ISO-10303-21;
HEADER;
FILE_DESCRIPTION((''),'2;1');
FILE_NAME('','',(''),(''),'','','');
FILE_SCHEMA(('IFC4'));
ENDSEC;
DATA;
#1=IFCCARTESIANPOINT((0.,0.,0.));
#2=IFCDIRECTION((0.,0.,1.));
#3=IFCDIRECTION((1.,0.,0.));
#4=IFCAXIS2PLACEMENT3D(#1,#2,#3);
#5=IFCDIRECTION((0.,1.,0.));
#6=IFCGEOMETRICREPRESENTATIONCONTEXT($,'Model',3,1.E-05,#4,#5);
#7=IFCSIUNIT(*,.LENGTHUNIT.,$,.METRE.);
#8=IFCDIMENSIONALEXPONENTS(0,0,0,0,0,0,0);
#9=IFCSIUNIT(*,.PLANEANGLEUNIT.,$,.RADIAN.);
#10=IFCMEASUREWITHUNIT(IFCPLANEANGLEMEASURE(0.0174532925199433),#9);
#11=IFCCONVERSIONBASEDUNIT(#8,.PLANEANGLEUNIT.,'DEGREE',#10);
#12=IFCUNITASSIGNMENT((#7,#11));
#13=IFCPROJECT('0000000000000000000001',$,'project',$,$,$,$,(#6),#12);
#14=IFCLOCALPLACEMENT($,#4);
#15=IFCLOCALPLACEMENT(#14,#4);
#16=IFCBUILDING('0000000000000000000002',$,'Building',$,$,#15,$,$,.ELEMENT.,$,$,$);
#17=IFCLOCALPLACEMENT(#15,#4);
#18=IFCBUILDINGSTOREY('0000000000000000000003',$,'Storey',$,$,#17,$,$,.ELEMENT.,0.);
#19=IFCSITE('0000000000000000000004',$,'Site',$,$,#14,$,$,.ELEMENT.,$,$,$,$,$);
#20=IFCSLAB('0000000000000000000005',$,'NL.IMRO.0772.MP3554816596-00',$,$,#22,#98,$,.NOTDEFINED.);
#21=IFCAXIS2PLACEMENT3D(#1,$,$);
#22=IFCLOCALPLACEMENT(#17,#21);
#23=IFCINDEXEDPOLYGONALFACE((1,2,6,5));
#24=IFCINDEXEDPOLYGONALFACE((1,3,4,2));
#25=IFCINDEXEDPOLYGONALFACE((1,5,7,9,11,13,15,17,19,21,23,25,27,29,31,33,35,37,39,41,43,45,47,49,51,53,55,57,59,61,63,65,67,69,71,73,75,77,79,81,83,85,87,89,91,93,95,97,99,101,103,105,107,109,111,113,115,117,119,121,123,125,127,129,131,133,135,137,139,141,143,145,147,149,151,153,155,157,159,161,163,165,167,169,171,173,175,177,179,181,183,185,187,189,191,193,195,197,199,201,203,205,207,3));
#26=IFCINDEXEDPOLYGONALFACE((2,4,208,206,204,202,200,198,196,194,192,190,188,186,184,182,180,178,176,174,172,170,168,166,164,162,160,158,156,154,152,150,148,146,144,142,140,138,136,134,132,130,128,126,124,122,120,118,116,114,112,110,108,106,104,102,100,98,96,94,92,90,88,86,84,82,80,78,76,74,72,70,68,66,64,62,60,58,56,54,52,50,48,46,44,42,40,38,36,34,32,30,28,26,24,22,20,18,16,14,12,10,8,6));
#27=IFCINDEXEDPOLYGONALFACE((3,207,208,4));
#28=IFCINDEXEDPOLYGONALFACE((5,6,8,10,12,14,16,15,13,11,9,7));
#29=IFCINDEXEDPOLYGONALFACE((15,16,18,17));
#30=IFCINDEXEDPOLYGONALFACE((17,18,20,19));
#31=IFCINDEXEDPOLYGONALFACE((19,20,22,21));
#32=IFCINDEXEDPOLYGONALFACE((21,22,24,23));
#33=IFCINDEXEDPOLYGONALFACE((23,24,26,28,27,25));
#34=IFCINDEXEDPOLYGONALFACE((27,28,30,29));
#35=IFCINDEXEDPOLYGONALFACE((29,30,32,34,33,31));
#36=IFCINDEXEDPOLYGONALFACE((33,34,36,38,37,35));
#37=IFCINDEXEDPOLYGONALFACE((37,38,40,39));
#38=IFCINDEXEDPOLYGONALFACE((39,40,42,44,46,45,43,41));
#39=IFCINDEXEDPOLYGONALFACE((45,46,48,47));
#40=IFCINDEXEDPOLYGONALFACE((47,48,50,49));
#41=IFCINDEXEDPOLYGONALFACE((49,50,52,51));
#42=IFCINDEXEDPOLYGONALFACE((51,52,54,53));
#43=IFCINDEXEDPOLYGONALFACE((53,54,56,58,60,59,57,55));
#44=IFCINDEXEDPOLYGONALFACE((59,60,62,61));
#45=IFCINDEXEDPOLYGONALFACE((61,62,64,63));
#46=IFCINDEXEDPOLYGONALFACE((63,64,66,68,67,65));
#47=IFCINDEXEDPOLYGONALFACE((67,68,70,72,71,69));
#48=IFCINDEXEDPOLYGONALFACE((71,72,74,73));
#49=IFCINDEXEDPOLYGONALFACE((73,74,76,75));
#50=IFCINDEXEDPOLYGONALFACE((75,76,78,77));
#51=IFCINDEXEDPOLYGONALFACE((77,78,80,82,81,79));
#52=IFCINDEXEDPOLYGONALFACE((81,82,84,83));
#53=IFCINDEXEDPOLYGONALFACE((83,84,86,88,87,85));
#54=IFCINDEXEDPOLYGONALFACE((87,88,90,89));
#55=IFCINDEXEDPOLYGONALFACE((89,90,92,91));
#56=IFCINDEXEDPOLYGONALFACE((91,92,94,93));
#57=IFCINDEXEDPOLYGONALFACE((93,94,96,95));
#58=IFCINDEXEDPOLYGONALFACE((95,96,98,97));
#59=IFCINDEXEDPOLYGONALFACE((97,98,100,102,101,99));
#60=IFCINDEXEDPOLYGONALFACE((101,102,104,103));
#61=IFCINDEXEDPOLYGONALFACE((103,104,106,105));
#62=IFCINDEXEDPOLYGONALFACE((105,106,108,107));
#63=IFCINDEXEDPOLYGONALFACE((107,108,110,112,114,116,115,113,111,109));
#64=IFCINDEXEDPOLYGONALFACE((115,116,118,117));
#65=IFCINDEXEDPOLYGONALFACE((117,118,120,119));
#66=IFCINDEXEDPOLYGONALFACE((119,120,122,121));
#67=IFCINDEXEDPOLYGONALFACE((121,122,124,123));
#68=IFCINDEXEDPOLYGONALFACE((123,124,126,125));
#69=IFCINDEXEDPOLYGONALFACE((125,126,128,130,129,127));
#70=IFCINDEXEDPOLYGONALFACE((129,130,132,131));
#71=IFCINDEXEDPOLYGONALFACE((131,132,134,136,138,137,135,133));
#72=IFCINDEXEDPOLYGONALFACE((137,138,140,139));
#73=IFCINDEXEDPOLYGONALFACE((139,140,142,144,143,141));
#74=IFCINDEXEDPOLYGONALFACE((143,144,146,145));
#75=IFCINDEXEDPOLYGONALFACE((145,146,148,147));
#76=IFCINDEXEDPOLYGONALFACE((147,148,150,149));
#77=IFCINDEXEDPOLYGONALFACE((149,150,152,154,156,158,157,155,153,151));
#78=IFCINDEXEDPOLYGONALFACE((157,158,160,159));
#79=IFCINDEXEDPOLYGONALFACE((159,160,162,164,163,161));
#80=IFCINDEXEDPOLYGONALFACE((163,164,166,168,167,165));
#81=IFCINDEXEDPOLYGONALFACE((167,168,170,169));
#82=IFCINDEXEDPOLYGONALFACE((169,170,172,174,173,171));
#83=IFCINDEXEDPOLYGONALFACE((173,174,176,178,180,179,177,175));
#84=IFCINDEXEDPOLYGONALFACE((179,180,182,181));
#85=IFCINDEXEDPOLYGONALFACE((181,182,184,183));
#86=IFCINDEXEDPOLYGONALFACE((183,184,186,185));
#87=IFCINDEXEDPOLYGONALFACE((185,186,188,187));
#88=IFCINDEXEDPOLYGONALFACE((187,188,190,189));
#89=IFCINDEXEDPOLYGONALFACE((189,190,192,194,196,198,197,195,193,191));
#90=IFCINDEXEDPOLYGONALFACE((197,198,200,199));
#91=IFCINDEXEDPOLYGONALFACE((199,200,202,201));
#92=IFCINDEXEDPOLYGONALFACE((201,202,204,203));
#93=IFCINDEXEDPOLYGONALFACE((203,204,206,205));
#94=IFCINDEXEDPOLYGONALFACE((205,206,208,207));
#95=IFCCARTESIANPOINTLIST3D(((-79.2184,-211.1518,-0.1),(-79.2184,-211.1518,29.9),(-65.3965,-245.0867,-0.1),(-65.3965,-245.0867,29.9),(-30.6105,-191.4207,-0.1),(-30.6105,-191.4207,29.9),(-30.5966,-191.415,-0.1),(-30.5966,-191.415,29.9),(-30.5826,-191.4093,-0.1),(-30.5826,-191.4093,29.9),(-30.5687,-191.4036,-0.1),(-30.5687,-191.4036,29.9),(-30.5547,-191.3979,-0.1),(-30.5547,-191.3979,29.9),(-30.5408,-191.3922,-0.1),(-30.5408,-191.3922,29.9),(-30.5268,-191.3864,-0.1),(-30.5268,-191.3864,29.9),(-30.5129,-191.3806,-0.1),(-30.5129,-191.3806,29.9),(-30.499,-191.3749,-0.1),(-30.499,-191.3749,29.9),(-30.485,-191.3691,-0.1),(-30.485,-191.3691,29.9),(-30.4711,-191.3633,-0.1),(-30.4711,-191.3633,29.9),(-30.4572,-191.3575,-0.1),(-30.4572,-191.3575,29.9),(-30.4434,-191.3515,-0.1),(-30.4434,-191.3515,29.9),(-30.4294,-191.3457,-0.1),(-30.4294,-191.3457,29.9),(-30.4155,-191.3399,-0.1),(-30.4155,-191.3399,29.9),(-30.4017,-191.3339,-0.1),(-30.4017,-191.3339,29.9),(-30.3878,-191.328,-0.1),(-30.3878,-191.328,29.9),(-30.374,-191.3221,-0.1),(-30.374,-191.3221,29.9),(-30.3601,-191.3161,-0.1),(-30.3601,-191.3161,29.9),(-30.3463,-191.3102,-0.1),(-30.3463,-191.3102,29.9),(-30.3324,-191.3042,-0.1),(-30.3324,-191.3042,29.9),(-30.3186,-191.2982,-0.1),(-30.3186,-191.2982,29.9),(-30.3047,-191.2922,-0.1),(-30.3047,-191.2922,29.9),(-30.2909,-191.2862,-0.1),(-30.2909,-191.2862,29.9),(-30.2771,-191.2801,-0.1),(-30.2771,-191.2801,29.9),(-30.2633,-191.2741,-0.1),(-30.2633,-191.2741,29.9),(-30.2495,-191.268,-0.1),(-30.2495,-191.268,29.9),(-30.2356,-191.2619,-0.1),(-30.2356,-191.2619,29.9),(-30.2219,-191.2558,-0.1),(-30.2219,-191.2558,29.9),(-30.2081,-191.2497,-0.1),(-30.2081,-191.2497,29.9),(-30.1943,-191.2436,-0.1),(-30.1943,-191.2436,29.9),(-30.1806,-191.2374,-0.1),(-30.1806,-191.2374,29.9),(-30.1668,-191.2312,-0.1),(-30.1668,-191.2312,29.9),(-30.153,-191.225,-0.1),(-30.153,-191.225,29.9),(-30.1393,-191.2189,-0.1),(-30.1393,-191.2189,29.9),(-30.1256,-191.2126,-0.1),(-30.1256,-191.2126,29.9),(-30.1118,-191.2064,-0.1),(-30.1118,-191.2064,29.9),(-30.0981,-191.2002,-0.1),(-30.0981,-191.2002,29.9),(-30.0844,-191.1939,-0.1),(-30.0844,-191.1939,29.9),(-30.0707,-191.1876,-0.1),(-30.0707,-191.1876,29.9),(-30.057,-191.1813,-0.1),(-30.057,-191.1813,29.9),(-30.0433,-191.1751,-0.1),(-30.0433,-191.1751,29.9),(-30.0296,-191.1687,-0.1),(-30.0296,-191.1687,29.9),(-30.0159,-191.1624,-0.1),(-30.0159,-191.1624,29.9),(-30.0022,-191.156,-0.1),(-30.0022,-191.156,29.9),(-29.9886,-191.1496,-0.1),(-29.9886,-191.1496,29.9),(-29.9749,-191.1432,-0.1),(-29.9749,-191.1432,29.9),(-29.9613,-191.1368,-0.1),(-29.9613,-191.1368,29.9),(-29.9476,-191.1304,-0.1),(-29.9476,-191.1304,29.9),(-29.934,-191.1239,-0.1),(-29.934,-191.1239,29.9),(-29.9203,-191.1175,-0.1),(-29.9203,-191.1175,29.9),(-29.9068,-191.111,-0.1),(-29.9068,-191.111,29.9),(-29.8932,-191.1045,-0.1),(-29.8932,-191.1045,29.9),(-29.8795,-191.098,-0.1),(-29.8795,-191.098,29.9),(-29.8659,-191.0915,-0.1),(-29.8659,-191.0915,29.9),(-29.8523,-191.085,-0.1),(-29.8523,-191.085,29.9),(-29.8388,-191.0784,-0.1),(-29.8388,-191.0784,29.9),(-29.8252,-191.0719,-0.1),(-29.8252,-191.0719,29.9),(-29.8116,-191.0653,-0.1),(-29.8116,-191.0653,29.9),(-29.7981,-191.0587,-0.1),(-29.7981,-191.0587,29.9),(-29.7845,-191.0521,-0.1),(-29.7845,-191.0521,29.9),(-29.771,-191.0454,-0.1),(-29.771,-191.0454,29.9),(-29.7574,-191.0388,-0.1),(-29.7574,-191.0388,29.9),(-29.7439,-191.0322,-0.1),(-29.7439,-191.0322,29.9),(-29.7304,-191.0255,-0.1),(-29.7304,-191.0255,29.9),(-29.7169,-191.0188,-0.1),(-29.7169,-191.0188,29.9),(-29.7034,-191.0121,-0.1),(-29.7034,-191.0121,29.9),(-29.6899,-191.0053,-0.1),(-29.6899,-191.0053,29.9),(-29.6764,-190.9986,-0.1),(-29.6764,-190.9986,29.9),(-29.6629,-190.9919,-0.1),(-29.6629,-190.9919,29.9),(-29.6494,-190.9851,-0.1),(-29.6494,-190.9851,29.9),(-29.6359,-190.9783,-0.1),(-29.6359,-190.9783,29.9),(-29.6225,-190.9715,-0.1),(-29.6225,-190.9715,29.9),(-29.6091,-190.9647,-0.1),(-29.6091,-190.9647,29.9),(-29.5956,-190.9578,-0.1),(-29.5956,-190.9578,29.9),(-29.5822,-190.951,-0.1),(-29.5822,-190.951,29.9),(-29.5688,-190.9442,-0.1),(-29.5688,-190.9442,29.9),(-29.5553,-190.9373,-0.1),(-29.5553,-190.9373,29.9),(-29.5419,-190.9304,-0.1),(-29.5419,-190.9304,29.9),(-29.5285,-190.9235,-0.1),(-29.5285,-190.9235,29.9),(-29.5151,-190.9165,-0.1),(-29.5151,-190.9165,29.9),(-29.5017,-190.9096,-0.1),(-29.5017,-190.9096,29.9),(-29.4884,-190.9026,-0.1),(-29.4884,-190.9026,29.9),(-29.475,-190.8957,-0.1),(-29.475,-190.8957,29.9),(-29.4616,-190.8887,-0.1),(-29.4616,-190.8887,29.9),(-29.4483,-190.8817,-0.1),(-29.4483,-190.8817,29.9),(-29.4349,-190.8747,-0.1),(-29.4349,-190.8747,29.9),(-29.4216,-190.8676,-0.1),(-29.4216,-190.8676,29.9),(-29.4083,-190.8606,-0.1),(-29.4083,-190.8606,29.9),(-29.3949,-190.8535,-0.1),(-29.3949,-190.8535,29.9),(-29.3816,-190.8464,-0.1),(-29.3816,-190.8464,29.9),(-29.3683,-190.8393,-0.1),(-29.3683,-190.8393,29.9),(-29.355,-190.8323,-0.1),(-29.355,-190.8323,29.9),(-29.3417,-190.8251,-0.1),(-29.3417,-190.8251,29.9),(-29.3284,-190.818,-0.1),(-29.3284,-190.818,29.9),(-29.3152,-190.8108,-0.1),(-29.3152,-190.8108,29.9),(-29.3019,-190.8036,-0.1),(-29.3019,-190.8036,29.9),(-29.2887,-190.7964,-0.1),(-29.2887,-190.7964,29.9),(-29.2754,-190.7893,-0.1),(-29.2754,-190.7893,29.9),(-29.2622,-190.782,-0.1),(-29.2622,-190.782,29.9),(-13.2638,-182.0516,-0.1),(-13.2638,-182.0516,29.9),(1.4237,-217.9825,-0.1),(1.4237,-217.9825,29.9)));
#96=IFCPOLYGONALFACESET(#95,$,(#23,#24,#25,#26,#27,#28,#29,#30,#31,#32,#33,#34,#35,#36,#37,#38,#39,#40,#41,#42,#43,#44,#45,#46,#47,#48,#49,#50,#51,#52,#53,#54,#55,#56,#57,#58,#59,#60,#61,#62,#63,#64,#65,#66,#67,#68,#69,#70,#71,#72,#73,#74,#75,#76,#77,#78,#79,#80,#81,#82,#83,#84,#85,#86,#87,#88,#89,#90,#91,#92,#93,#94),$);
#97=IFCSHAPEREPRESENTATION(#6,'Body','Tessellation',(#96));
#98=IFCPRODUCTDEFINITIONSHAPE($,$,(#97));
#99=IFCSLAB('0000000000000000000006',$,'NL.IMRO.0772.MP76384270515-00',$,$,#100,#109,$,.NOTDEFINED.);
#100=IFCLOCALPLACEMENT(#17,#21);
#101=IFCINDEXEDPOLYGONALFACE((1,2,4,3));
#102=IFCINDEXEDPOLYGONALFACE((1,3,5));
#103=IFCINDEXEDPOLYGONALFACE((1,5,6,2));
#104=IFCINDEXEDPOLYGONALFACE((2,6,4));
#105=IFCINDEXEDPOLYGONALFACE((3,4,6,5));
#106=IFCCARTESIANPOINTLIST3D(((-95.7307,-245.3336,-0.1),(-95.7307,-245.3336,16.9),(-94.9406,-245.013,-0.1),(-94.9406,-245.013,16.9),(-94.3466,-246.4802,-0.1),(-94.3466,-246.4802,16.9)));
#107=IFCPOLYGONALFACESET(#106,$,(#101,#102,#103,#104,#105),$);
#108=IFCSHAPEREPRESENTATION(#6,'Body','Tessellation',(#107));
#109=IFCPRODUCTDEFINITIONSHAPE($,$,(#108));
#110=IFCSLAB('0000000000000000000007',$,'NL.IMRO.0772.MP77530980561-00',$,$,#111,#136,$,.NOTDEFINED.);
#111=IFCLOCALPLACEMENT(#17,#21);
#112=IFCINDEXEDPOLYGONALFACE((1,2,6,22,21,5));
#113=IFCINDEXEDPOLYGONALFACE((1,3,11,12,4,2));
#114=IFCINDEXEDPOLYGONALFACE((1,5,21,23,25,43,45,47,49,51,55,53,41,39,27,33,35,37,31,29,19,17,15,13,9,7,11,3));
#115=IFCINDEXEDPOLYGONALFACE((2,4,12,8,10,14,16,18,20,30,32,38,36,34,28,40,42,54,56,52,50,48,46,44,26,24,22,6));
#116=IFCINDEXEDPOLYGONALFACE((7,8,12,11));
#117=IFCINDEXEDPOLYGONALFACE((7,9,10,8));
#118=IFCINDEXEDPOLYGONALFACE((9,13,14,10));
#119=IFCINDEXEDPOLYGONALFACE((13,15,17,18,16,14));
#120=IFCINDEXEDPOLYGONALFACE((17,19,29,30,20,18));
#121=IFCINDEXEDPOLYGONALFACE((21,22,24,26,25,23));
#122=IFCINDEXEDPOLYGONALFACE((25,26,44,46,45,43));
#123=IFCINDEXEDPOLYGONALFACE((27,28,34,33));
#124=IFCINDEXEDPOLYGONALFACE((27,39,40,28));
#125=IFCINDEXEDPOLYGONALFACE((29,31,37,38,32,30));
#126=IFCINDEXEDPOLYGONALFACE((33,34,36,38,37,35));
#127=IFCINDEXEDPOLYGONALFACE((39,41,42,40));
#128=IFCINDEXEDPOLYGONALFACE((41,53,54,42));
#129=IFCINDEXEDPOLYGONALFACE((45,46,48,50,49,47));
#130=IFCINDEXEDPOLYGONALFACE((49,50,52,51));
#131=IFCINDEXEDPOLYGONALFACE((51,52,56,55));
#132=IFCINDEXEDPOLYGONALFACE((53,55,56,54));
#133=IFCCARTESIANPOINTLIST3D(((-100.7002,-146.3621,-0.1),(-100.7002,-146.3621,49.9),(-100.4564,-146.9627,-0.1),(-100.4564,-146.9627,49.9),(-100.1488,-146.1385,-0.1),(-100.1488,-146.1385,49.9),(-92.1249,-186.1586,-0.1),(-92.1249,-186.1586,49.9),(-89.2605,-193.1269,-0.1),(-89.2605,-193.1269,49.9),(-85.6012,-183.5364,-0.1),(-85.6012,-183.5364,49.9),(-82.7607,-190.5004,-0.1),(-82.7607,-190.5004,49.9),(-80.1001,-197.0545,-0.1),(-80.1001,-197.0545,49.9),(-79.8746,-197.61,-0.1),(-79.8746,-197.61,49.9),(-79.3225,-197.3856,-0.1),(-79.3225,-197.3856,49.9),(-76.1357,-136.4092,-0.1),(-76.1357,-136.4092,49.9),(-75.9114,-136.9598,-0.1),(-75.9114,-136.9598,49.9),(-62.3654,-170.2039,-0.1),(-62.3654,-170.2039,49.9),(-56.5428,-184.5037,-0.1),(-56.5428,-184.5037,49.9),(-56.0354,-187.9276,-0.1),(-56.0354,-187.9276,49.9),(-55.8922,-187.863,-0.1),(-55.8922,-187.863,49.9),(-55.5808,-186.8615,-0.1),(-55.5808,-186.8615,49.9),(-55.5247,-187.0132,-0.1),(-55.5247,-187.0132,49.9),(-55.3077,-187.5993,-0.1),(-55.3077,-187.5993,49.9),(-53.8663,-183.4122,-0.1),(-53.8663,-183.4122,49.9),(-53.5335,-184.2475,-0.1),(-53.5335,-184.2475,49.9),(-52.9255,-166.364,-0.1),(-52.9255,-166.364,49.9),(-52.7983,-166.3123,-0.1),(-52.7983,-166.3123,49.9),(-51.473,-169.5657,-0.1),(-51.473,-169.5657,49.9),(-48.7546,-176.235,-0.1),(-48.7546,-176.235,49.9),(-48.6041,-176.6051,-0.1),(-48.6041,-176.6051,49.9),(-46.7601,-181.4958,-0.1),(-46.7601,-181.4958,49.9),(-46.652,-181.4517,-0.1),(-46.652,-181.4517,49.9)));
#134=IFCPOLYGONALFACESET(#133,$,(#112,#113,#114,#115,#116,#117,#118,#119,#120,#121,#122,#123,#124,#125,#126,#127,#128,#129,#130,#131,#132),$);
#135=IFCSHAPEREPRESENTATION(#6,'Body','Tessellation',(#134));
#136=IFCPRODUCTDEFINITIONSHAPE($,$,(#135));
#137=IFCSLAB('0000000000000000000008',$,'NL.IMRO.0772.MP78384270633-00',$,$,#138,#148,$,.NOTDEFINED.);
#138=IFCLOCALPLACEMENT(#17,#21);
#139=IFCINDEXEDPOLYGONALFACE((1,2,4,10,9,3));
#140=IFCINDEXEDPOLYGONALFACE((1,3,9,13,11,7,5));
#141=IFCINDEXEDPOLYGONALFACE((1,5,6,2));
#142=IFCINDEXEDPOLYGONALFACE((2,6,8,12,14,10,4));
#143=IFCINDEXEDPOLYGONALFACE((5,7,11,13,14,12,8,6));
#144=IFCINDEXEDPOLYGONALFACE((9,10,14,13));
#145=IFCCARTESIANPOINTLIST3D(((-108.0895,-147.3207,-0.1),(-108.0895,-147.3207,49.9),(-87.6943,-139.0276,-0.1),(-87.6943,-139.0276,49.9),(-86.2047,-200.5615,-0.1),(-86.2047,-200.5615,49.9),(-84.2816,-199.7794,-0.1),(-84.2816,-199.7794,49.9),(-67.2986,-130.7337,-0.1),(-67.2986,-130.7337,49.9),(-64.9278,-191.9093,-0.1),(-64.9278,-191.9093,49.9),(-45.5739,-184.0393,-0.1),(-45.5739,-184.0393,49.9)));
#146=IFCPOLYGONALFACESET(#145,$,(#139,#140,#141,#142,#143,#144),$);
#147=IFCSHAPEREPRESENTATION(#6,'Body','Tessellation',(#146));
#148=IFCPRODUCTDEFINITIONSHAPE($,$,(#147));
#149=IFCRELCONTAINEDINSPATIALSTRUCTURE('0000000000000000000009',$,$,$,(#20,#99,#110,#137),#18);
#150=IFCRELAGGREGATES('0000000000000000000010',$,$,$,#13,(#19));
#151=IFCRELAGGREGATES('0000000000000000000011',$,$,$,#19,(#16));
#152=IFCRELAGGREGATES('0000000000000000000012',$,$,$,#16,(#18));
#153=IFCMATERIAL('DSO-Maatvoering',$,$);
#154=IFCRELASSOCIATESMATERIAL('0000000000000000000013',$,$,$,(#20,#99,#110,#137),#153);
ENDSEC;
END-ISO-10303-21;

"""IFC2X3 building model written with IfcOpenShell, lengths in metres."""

from ifc_helpers import new_model, entity, si_unit, converted_unit, direction, frame, origin_with_axes, place, context, project, spatial, polyline, outline, extrude, material, element, save


model = new_model("IFC2X3")

# Units and contexts
model_context = context("Model", 3, precision=1e-05, world=origin_with_axes(), true_north=direction((0.0, 1.0, 0.0)))
ifc_project = project(units=[si_unit("LENGTHUNIT", "METRE"), converted_unit("PLANEANGLEUNIT", "DEGREE", entity("IfcPlaneAngleMeasure", 0.0174532925199433), si_unit("PLANEANGLEUNIT", "RADIAN"), dimensions=[0, 0, 0, 0, 0, 0, 0])], contexts=[model_context])

# Site, building, storey
site_placement = place(None, origin_with_axes())
site = spatial("IfcSite", under=ifc_project, at=site_placement, Name="Site", CompositionType="ELEMENT")
building_placement = place(site_placement, origin_with_axes())
building = spatial("IfcBuilding", under=site, at=building_placement, Name="Building", CompositionType="ELEMENT")
storey_placement = place(building_placement, origin_with_axes())
storey = spatial("IfcBuildingStorey", under=building, at=storey_placement, Name="Storey", CompositionType="ELEMENT", Elevation=0.0)

# Slabs
ifc_material = material(Name="DSO-Maatvoering")
slab_1_placement = place(storey_placement, frame((0.0, 0.0, -0.1), z_axis=(0.0, 0.0, 1.0), x_axis=(1.0, 0.0, 0.0)))
element("IfcSlab", 1, at=slab_1_placement, inside=storey, material=ifc_material, Name="NL.IMRO.0772.MP3554816596-00", PredefinedType="NOTDEFINED", context=model_context, shape_type="SweptSolid", body=[
    extrude(outline(polyline([(-13.2638, -182.0516), (1.4237, -217.9825), (-65.3965, -245.0867), (-79.2184, -211.1518), (-30.6105, -191.4207), (-30.5966, -191.415), (-30.5826, -191.4093), (-30.5687, -191.4036), (-30.5547, -191.3979), (-30.5408, -191.3922), (-30.5268, -191.3864), (-30.5129, -191.3806), (-30.499, -191.3749), (-30.485, -191.3691), (-30.4711, -191.3633), (-30.4572, -191.3575), (-30.4434, -191.3515), (-30.4294, -191.3457), (-30.4155, -191.3399), (-30.4017, -191.3339), (-30.3878, -191.328), (-30.374, -191.3221), (-30.3601, -191.3161), (-30.3463, -191.3102), (-30.3324, -191.3042), (-30.3186, -191.2982), (-30.3047, -191.2922), (-30.2909, -191.2862), (-30.2771, -191.2801), (-30.2633, -191.2741), (-30.2495, -191.268), (-30.2356, -191.2619), (-30.2219, -191.2558), (-30.2081, -191.2497), (-30.1943, -191.2436), (-30.1806, -191.2374), (-30.1668, -191.2312), (-30.153, -191.225), (-30.1393, -191.2189), (-30.1256, -191.2126), (-30.1118, -191.2064), (-30.0981, -191.2002), (-30.0844, -191.1939), (-30.0707, -191.1876), (-30.057, -191.1813), (-30.0433, -191.1751), (-30.0296, -191.1687), (-30.0159, -191.1624), (-30.0022, -191.156), (-29.9886, -191.1496), (-29.9749, -191.1432), (-29.9613, -191.1368), (-29.9476, -191.1304), (-29.934, -191.1239), (-29.9203, -191.1175), (-29.9068, -191.111), (-29.8932, -191.1045), (-29.8795, -191.098), (-29.8659, -191.0915), (-29.8523, -191.085), (-29.8388, -191.0784), (-29.8252, -191.0719), (-29.8116, -191.0653), (-29.7981, -191.0587), (-29.7845, -191.0521), (-29.771, -191.0454), (-29.7574, -191.0388), (-29.7439, -191.0322), (-29.7304, -191.0255), (-29.7169, -191.0188), (-29.7034, -191.0121), (-29.6899, -191.0053), (-29.6764, -190.9986), (-29.6629, -190.9919), (-29.6494, -190.9851), (-29.6359, -190.9783), (-29.6225, -190.9715), (-29.6091, -190.9647), (-29.5956, -190.9578), (-29.5822, -190.951), (-29.5688, -190.9442), (-29.5553, -190.9373), (-29.5419, -190.9304), (-29.5285, -190.9235), (-29.5151, -190.9165), (-29.5017, -190.9096), (-29.4884, -190.9026), (-29.475, -190.8957), (-29.4616, -190.8887), (-29.4483, -190.8817), (-29.4349, -190.8747), (-29.4216, -190.8676), (-29.4083, -190.8606), (-29.3949, -190.8535), (-29.3816, -190.8464), (-29.3683, -190.8393), (-29.355, -190.8323), (-29.3417, -190.8251), (-29.3284, -190.818), (-29.3152, -190.8108), (-29.3019, -190.8036), (-29.2887, -190.7964), (-29.2754, -190.7893), (-29.2622, -190.782), (-13.2638, -182.0516)])), origin_with_axes(), (0.0, 0.0, 1.0), 30.0),
])
slab_2_placement = place(storey_placement, frame((0.0, 0.0, -0.1), z_axis=(0.0, 0.0, 1.0), x_axis=(1.0, 0.0, 0.0)))
element("IfcSlab", 2, at=slab_2_placement, inside=storey, material=ifc_material, Name="NL.IMRO.0772.MP76384270515-00", PredefinedType="NOTDEFINED", context=model_context, shape_type="SweptSolid", body=[
    extrude(outline(polyline([(-94.9406, -245.013), (-94.3466, -246.4802), (-95.7307, -245.3336), (-94.9406, -245.013)])), origin_with_axes(), (0.0, 0.0, 1.0), 17.0),
])
for number, where, z_axis, x_axis, name in (
    (3, (0.0, 0.0, -0.1), (0.0, 0.0, 1.0), (1.0, 0.0, 0.0), "NL.IMRO.0772.MP77530980561-00"),
):
    element("IfcSlab", number, at=place(storey_placement, frame(where, z_axis=z_axis, x_axis=x_axis)), inside=storey, material=ifc_material, Name=name, PredefinedType="NOTDEFINED", context=model_context, shape_type="SweptSolid", body=[
        extrude(outline(polyline([(-52.7983, -166.3123), (-51.473, -169.5657), (-48.7546, -176.235), (-48.6041, -176.6051), (-46.652, -181.4517), (-46.7601, -181.4958), (-53.5335, -184.2475), (-53.8663, -183.4122), (-56.5428, -184.5037), (-55.5808, -186.8615), (-55.5247, -187.0132), (-55.3077, -187.5993), (-55.8922, -187.863), (-56.0354, -187.9276), (-79.3225, -197.3856), (-79.8746, -197.61), (-80.1001, -197.0545), (-82.7607, -190.5004), (-89.2605, -193.1269), (-92.1249, -186.1586), (-85.6012, -183.5364), (-100.4564, -146.9627), (-100.7002, -146.3621), (-100.1488, -146.1385), (-76.1357, -136.4092), (-75.9114, -136.9598), (-62.3654, -170.2039), (-52.9255, -166.364), (-52.7983, -166.3123)])), origin_with_axes(), (0.0, 0.0, 1.0), 50.0),
    ])
slab_3_placement = place(storey_placement, frame((0.0, 0.0, -0.1), z_axis=(0.0, 0.0, 1.0), x_axis=(1.0, 0.0, 0.0)))
element("IfcSlab", 4, at=slab_3_placement, inside=storey, material=ifc_material, Name="NL.IMRO.0772.MP78384270633-00", PredefinedType="NOTDEFINED", context=model_context, shape_type="SweptSolid", body=[
    extrude(outline(polyline([(-87.6943, -139.0276), (-67.2986, -130.7337), (-45.5739, -184.0393), (-64.9278, -191.9093), (-84.2816, -199.7794), (-86.2047, -200.5615), (-108.0895, -147.3207), (-87.6943, -139.0276)])), origin_with_axes(), (0.0, 0.0, 1.0), 50.0),
])

save(model, "model.ifc")
